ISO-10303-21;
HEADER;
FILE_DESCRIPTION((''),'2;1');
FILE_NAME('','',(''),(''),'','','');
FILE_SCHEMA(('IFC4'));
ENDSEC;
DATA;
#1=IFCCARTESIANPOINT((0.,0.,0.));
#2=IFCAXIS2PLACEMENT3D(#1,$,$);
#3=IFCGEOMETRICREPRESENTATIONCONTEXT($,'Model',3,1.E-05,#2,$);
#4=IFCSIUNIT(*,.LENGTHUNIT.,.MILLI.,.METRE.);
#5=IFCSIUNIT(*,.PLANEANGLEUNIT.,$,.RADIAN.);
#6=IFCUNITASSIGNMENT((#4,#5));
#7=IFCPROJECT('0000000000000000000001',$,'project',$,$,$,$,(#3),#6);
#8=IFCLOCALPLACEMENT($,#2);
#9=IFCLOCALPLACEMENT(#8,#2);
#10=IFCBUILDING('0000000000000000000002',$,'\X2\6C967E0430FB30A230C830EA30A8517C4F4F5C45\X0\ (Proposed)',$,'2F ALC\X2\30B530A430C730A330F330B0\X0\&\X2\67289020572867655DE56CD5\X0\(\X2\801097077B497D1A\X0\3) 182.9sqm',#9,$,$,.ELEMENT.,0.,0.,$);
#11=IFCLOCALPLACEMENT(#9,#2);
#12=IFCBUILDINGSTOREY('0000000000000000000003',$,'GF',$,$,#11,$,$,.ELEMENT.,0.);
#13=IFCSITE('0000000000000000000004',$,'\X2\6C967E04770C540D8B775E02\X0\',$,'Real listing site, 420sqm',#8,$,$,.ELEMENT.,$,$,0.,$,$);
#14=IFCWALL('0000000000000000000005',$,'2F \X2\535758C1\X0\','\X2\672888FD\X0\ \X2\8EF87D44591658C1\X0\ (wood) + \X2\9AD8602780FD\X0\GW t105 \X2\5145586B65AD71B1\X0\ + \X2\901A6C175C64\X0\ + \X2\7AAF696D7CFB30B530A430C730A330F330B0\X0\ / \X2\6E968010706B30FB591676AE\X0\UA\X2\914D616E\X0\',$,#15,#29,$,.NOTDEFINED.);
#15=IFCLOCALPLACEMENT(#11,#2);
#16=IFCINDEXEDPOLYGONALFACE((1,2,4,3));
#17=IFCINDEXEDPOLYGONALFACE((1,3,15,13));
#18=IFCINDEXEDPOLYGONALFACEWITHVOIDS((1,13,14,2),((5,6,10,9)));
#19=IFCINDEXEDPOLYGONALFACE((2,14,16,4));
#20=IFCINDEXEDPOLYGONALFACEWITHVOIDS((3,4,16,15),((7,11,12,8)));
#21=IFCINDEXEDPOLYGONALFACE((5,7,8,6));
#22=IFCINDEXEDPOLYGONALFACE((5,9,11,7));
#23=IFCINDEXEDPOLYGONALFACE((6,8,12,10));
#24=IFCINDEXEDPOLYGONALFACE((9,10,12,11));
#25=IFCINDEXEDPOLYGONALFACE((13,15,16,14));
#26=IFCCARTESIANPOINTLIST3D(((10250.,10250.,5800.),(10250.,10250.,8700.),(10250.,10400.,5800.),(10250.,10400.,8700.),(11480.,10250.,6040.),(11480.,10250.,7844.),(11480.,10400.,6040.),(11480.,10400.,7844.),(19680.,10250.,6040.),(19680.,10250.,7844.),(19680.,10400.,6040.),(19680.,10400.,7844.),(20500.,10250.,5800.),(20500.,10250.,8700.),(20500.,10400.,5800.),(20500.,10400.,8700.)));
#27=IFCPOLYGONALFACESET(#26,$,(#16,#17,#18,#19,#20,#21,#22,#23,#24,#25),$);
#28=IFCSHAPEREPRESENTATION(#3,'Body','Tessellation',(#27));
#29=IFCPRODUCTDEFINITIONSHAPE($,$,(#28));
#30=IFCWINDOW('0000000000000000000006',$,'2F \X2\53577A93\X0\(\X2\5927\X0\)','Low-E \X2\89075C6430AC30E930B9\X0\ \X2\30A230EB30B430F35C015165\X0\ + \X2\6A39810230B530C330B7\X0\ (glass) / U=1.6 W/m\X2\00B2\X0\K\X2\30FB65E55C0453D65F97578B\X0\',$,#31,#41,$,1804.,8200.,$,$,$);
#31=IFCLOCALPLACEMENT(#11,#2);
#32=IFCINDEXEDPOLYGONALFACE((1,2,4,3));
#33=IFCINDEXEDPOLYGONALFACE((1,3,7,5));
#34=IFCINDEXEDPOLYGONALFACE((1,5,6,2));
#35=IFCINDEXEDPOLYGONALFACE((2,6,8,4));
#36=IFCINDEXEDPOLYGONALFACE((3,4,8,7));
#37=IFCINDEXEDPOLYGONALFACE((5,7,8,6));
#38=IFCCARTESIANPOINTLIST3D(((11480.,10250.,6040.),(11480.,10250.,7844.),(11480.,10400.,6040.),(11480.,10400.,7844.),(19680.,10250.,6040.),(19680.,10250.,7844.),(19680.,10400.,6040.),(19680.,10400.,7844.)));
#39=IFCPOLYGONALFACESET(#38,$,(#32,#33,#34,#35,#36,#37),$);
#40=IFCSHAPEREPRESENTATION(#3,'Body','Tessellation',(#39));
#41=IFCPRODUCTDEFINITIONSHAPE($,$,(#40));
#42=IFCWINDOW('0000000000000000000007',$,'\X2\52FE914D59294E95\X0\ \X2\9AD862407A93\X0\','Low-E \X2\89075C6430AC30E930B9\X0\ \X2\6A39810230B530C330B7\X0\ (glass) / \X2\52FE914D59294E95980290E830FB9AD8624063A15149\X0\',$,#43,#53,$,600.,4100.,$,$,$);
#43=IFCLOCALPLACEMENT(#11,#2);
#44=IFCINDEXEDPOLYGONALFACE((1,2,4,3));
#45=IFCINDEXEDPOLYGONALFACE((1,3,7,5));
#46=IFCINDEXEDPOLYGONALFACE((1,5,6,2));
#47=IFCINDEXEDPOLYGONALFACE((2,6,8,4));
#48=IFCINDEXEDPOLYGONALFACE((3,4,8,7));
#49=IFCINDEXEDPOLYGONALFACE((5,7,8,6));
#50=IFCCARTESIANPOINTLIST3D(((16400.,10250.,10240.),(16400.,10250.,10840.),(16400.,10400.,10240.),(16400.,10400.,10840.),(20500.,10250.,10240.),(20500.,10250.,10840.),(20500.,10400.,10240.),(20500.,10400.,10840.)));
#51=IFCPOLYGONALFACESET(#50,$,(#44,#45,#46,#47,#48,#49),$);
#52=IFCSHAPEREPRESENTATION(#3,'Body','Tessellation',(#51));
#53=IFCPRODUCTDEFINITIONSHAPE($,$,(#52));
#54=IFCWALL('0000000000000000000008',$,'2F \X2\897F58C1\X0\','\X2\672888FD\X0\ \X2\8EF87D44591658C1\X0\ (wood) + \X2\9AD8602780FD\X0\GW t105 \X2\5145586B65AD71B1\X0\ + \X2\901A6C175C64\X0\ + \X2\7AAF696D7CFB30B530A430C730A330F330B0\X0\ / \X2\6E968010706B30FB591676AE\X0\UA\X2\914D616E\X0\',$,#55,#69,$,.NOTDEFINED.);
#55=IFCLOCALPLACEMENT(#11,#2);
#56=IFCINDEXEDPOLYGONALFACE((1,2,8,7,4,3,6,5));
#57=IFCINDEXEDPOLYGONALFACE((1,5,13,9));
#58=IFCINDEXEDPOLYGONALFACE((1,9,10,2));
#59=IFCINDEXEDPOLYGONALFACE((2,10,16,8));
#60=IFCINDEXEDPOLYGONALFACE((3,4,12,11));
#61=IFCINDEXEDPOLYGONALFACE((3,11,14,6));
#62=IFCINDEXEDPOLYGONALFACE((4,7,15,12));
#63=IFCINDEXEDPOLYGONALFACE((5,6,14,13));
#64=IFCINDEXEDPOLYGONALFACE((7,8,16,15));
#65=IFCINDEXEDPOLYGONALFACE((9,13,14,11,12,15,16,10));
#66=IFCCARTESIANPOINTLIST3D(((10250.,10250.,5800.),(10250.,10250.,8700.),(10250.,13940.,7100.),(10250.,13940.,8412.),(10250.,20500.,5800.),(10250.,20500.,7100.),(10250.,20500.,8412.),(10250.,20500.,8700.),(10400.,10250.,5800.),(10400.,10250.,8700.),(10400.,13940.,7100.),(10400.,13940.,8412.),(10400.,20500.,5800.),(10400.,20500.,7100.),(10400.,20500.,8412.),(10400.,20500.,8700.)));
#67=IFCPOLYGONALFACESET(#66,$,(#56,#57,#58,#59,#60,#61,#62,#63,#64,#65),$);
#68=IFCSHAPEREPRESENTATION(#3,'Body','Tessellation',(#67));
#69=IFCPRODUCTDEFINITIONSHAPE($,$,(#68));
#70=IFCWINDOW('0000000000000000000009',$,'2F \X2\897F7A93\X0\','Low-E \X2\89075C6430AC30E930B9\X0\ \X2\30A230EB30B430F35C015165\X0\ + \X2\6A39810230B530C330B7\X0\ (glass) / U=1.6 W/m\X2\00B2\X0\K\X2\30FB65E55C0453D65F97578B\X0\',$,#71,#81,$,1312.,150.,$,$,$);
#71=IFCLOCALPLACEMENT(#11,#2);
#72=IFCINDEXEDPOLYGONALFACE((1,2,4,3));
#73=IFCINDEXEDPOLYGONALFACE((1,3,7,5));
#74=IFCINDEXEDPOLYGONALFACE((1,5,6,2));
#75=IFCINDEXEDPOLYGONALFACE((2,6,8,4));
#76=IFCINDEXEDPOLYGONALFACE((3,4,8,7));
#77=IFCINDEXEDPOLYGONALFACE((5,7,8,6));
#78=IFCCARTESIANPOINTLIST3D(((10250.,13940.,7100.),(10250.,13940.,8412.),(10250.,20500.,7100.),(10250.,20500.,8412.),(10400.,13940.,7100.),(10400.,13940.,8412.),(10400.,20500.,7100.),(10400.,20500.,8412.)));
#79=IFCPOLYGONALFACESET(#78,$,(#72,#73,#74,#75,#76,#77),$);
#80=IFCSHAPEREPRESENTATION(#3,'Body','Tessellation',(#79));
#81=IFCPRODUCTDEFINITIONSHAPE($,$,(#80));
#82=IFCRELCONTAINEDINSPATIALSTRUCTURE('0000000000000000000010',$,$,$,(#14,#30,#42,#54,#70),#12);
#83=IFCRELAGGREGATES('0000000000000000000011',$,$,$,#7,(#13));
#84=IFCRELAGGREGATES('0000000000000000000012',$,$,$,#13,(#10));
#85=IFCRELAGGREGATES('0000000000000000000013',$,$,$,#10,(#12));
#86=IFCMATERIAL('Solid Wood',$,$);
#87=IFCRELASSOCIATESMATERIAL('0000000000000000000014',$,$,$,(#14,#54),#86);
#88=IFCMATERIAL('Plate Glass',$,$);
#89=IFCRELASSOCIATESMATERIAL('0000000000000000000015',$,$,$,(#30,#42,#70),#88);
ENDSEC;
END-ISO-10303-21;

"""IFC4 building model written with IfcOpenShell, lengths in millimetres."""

from ifc_helpers import new_model, si_unit, frame, frame_2d, origin, place, context, project, spatial, rectangle, extrude, material, element, fill, save


model = new_model("IFC4")

# Units and contexts
model_context = context("Model", 3, precision=1e-05, world=origin())
ifc_project = project(units=[si_unit("LENGTHUNIT", "METRE", prefix="MILLI"), si_unit("PLANEANGLEUNIT", "RADIAN")], contexts=[model_context])

# Site, building, storey
site_placement = place(None, origin())
site = spatial("IfcSite", under=ifc_project, at=site_placement, Name="沖縄県名護市", ObjectType="Real listing site, 420sqm", CompositionType="ELEMENT", RefElevation=0.0)
building_placement = place(site_placement, origin())
building = spatial("IfcBuilding", under=site, at=building_placement, Name="沖縄・アトリエ兼住居 (Proposed)", ObjectType="2F ALCサイディング&木造在来工法(耐震等級3) 182.9sqm", CompositionType="ELEMENT", ElevationOfRefHeight=0.0, ElevationOfTerrain=0.0)
storey_placement = place(building_placement, origin())
storey = spatial("IfcBuildingStorey", under=building, at=storey_placement, Name="GF", CompositionType="ELEMENT", Elevation=0.0)

# Shared definitions
ifc_material_1 = material(Name="Solid Wood")

# Shared definitions
ifc_material_2 = material(Name="Plate Glass")

# Wall, openings, windows
wall_1_placement = place(storey_placement, frame((5125.0, 5125.0, 2900.0)))
wall_1 = element("IfcWall", 1, at=wall_1_placement, inside=storey, material=ifc_material_1, Name="2F 南壁", Description="木製 軸組外壁 (wood) + 高性能GW t105 充填断熱 + 通気層 + 窯業系サイディング / 準耐火・外皮UA配慮", PredefinedType="NOTDEFINED", context=model_context, shape_type="SweptSolid", body=[
    extrude(rectangle(XDim=10250.0, YDim=150.0, at=frame_2d((5125.0, 75.0))), frame((5125.0, 5125.0, 2900.0)), (0.0, 0.0, 1.0), 2900.0),
])
opening_1_placement = place(storey_placement, frame((5740.0, 5125.0, 3020.0)))
opening_1 = element("IfcOpeningElement", 2, at=opening_1_placement, cuts=wall_1, PredefinedType="NOTDEFINED", context=model_context, shape_type="SweptSolid", body=[
    extrude(rectangle(XDim=8200.0, YDim=150.0, at=frame_2d((4100.0, 75.0))), frame((5740.0, 5125.0, 3020.0)), (0.0, 0.0, 1.0), 1804.0),
])
opening_2_placement = place(storey_placement, frame((8200.0, 5125.0, 5120.0)))
opening_2 = element("IfcOpeningElement", 3, at=opening_2_placement, cuts=wall_1, PredefinedType="NOTDEFINED", context=model_context, shape_type="SweptSolid", body=[
    extrude(rectangle(XDim=4100.0, YDim=150.0, at=frame_2d((2050.0, 75.0))), frame((8200.0, 5125.0, 5120.0)), (0.0, 0.0, 1.0), 600.0),
])
window_1_placement = place(storey_placement, frame((5740.0, 5125.0, 3020.0)))
window_1 = element("IfcWindow", 4, at=window_1_placement, inside=storey, material=ifc_material_2, Name="2F 南窓(大)", Description="Low-E 複層ガラス アルゴン封入 + 樹脂サッシ (glass) / U=1.6 W/m²K・日射取得型", OverallHeight=1804.0, OverallWidth=8200.0, context=model_context, shape_type="SweptSolid", body=[
    extrude(rectangle(XDim=8200.0, YDim=150.0, at=frame_2d((4100.0, 75.0))), frame((5740.0, 5125.0, 3020.0)), (0.0, 0.0, 1.0), 1804.0),
])
fill(opening_1, window_1)
window_2_placement = place(storey_placement, frame((8200.0, 5125.0, 5120.0)))
window_2 = element("IfcWindow", 5, at=window_2_placement, inside=storey, material=ifc_material_2, Name="勾配天井 高所窓", Description="Low-E 複層ガラス 樹脂サッシ (glass) / 勾配天井頂部・高所採光", OverallHeight=600.0, OverallWidth=4100.0, context=model_context, shape_type="SweptSolid", body=[
    extrude(rectangle(XDim=4100.0, YDim=150.0, at=frame_2d((2050.0, 75.0))), frame((8200.0, 5125.0, 5120.0)), (0.0, 0.0, 1.0), 600.0),
])
fill(opening_2, window_2)

# Wall, opening, window
wall_2_placement = place(storey_placement, frame((5125.0, 5125.0, 2900.0)))
wall_2 = element("IfcWall", 6, at=wall_2_placement, inside=storey, material=ifc_material_1, Name="2F 西壁", Description="木製 軸組外壁 (wood) + 高性能GW t105 充填断熱 + 通気層 + 窯業系サイディング / 準耐火・外皮UA配慮", PredefinedType="NOTDEFINED", context=model_context, shape_type="SweptSolid", body=[
    extrude(rectangle(XDim=150.0, YDim=10250.0, at=frame_2d((75.0, 5125.0))), frame((5125.0, 5125.0, 2900.0)), (0.0, 0.0, 1.0), 2900.0),
])
opening_3_placement = place(storey_placement, frame((5125.0, 6970.0, 3550.0)))
opening_3 = element("IfcOpeningElement", 7, at=opening_3_placement, cuts=wall_2, PredefinedType="NOTDEFINED", context=model_context, shape_type="SweptSolid", body=[
    extrude(rectangle(XDim=150.0, YDim=6560.0, at=frame_2d((75.0, 3280.0))), frame((5125.0, 6970.0, 3550.0)), (0.0, 0.0, 1.0), 1312.0),
])
window_3_placement = place(storey_placement, frame((5125.0, 6970.0, 3550.0)))
window_3 = element("IfcWindow", 8, at=window_3_placement, inside=storey, material=ifc_material_2, Name="2F 西窓", Description="Low-E 複層ガラス アルゴン封入 + 樹脂サッシ (glass) / U=1.6 W/m²K・日射取得型", OverallHeight=1312.0, OverallWidth=150.0, context=model_context, shape_type="SweptSolid", body=[
    extrude(rectangle(XDim=150.0, YDim=6560.0, at=frame_2d((75.0, 3280.0))), frame((5125.0, 6970.0, 3550.0)), (0.0, 0.0, 1.0), 1312.0),
])
fill(opening_3, window_3)

save(model, "model.ifc")
